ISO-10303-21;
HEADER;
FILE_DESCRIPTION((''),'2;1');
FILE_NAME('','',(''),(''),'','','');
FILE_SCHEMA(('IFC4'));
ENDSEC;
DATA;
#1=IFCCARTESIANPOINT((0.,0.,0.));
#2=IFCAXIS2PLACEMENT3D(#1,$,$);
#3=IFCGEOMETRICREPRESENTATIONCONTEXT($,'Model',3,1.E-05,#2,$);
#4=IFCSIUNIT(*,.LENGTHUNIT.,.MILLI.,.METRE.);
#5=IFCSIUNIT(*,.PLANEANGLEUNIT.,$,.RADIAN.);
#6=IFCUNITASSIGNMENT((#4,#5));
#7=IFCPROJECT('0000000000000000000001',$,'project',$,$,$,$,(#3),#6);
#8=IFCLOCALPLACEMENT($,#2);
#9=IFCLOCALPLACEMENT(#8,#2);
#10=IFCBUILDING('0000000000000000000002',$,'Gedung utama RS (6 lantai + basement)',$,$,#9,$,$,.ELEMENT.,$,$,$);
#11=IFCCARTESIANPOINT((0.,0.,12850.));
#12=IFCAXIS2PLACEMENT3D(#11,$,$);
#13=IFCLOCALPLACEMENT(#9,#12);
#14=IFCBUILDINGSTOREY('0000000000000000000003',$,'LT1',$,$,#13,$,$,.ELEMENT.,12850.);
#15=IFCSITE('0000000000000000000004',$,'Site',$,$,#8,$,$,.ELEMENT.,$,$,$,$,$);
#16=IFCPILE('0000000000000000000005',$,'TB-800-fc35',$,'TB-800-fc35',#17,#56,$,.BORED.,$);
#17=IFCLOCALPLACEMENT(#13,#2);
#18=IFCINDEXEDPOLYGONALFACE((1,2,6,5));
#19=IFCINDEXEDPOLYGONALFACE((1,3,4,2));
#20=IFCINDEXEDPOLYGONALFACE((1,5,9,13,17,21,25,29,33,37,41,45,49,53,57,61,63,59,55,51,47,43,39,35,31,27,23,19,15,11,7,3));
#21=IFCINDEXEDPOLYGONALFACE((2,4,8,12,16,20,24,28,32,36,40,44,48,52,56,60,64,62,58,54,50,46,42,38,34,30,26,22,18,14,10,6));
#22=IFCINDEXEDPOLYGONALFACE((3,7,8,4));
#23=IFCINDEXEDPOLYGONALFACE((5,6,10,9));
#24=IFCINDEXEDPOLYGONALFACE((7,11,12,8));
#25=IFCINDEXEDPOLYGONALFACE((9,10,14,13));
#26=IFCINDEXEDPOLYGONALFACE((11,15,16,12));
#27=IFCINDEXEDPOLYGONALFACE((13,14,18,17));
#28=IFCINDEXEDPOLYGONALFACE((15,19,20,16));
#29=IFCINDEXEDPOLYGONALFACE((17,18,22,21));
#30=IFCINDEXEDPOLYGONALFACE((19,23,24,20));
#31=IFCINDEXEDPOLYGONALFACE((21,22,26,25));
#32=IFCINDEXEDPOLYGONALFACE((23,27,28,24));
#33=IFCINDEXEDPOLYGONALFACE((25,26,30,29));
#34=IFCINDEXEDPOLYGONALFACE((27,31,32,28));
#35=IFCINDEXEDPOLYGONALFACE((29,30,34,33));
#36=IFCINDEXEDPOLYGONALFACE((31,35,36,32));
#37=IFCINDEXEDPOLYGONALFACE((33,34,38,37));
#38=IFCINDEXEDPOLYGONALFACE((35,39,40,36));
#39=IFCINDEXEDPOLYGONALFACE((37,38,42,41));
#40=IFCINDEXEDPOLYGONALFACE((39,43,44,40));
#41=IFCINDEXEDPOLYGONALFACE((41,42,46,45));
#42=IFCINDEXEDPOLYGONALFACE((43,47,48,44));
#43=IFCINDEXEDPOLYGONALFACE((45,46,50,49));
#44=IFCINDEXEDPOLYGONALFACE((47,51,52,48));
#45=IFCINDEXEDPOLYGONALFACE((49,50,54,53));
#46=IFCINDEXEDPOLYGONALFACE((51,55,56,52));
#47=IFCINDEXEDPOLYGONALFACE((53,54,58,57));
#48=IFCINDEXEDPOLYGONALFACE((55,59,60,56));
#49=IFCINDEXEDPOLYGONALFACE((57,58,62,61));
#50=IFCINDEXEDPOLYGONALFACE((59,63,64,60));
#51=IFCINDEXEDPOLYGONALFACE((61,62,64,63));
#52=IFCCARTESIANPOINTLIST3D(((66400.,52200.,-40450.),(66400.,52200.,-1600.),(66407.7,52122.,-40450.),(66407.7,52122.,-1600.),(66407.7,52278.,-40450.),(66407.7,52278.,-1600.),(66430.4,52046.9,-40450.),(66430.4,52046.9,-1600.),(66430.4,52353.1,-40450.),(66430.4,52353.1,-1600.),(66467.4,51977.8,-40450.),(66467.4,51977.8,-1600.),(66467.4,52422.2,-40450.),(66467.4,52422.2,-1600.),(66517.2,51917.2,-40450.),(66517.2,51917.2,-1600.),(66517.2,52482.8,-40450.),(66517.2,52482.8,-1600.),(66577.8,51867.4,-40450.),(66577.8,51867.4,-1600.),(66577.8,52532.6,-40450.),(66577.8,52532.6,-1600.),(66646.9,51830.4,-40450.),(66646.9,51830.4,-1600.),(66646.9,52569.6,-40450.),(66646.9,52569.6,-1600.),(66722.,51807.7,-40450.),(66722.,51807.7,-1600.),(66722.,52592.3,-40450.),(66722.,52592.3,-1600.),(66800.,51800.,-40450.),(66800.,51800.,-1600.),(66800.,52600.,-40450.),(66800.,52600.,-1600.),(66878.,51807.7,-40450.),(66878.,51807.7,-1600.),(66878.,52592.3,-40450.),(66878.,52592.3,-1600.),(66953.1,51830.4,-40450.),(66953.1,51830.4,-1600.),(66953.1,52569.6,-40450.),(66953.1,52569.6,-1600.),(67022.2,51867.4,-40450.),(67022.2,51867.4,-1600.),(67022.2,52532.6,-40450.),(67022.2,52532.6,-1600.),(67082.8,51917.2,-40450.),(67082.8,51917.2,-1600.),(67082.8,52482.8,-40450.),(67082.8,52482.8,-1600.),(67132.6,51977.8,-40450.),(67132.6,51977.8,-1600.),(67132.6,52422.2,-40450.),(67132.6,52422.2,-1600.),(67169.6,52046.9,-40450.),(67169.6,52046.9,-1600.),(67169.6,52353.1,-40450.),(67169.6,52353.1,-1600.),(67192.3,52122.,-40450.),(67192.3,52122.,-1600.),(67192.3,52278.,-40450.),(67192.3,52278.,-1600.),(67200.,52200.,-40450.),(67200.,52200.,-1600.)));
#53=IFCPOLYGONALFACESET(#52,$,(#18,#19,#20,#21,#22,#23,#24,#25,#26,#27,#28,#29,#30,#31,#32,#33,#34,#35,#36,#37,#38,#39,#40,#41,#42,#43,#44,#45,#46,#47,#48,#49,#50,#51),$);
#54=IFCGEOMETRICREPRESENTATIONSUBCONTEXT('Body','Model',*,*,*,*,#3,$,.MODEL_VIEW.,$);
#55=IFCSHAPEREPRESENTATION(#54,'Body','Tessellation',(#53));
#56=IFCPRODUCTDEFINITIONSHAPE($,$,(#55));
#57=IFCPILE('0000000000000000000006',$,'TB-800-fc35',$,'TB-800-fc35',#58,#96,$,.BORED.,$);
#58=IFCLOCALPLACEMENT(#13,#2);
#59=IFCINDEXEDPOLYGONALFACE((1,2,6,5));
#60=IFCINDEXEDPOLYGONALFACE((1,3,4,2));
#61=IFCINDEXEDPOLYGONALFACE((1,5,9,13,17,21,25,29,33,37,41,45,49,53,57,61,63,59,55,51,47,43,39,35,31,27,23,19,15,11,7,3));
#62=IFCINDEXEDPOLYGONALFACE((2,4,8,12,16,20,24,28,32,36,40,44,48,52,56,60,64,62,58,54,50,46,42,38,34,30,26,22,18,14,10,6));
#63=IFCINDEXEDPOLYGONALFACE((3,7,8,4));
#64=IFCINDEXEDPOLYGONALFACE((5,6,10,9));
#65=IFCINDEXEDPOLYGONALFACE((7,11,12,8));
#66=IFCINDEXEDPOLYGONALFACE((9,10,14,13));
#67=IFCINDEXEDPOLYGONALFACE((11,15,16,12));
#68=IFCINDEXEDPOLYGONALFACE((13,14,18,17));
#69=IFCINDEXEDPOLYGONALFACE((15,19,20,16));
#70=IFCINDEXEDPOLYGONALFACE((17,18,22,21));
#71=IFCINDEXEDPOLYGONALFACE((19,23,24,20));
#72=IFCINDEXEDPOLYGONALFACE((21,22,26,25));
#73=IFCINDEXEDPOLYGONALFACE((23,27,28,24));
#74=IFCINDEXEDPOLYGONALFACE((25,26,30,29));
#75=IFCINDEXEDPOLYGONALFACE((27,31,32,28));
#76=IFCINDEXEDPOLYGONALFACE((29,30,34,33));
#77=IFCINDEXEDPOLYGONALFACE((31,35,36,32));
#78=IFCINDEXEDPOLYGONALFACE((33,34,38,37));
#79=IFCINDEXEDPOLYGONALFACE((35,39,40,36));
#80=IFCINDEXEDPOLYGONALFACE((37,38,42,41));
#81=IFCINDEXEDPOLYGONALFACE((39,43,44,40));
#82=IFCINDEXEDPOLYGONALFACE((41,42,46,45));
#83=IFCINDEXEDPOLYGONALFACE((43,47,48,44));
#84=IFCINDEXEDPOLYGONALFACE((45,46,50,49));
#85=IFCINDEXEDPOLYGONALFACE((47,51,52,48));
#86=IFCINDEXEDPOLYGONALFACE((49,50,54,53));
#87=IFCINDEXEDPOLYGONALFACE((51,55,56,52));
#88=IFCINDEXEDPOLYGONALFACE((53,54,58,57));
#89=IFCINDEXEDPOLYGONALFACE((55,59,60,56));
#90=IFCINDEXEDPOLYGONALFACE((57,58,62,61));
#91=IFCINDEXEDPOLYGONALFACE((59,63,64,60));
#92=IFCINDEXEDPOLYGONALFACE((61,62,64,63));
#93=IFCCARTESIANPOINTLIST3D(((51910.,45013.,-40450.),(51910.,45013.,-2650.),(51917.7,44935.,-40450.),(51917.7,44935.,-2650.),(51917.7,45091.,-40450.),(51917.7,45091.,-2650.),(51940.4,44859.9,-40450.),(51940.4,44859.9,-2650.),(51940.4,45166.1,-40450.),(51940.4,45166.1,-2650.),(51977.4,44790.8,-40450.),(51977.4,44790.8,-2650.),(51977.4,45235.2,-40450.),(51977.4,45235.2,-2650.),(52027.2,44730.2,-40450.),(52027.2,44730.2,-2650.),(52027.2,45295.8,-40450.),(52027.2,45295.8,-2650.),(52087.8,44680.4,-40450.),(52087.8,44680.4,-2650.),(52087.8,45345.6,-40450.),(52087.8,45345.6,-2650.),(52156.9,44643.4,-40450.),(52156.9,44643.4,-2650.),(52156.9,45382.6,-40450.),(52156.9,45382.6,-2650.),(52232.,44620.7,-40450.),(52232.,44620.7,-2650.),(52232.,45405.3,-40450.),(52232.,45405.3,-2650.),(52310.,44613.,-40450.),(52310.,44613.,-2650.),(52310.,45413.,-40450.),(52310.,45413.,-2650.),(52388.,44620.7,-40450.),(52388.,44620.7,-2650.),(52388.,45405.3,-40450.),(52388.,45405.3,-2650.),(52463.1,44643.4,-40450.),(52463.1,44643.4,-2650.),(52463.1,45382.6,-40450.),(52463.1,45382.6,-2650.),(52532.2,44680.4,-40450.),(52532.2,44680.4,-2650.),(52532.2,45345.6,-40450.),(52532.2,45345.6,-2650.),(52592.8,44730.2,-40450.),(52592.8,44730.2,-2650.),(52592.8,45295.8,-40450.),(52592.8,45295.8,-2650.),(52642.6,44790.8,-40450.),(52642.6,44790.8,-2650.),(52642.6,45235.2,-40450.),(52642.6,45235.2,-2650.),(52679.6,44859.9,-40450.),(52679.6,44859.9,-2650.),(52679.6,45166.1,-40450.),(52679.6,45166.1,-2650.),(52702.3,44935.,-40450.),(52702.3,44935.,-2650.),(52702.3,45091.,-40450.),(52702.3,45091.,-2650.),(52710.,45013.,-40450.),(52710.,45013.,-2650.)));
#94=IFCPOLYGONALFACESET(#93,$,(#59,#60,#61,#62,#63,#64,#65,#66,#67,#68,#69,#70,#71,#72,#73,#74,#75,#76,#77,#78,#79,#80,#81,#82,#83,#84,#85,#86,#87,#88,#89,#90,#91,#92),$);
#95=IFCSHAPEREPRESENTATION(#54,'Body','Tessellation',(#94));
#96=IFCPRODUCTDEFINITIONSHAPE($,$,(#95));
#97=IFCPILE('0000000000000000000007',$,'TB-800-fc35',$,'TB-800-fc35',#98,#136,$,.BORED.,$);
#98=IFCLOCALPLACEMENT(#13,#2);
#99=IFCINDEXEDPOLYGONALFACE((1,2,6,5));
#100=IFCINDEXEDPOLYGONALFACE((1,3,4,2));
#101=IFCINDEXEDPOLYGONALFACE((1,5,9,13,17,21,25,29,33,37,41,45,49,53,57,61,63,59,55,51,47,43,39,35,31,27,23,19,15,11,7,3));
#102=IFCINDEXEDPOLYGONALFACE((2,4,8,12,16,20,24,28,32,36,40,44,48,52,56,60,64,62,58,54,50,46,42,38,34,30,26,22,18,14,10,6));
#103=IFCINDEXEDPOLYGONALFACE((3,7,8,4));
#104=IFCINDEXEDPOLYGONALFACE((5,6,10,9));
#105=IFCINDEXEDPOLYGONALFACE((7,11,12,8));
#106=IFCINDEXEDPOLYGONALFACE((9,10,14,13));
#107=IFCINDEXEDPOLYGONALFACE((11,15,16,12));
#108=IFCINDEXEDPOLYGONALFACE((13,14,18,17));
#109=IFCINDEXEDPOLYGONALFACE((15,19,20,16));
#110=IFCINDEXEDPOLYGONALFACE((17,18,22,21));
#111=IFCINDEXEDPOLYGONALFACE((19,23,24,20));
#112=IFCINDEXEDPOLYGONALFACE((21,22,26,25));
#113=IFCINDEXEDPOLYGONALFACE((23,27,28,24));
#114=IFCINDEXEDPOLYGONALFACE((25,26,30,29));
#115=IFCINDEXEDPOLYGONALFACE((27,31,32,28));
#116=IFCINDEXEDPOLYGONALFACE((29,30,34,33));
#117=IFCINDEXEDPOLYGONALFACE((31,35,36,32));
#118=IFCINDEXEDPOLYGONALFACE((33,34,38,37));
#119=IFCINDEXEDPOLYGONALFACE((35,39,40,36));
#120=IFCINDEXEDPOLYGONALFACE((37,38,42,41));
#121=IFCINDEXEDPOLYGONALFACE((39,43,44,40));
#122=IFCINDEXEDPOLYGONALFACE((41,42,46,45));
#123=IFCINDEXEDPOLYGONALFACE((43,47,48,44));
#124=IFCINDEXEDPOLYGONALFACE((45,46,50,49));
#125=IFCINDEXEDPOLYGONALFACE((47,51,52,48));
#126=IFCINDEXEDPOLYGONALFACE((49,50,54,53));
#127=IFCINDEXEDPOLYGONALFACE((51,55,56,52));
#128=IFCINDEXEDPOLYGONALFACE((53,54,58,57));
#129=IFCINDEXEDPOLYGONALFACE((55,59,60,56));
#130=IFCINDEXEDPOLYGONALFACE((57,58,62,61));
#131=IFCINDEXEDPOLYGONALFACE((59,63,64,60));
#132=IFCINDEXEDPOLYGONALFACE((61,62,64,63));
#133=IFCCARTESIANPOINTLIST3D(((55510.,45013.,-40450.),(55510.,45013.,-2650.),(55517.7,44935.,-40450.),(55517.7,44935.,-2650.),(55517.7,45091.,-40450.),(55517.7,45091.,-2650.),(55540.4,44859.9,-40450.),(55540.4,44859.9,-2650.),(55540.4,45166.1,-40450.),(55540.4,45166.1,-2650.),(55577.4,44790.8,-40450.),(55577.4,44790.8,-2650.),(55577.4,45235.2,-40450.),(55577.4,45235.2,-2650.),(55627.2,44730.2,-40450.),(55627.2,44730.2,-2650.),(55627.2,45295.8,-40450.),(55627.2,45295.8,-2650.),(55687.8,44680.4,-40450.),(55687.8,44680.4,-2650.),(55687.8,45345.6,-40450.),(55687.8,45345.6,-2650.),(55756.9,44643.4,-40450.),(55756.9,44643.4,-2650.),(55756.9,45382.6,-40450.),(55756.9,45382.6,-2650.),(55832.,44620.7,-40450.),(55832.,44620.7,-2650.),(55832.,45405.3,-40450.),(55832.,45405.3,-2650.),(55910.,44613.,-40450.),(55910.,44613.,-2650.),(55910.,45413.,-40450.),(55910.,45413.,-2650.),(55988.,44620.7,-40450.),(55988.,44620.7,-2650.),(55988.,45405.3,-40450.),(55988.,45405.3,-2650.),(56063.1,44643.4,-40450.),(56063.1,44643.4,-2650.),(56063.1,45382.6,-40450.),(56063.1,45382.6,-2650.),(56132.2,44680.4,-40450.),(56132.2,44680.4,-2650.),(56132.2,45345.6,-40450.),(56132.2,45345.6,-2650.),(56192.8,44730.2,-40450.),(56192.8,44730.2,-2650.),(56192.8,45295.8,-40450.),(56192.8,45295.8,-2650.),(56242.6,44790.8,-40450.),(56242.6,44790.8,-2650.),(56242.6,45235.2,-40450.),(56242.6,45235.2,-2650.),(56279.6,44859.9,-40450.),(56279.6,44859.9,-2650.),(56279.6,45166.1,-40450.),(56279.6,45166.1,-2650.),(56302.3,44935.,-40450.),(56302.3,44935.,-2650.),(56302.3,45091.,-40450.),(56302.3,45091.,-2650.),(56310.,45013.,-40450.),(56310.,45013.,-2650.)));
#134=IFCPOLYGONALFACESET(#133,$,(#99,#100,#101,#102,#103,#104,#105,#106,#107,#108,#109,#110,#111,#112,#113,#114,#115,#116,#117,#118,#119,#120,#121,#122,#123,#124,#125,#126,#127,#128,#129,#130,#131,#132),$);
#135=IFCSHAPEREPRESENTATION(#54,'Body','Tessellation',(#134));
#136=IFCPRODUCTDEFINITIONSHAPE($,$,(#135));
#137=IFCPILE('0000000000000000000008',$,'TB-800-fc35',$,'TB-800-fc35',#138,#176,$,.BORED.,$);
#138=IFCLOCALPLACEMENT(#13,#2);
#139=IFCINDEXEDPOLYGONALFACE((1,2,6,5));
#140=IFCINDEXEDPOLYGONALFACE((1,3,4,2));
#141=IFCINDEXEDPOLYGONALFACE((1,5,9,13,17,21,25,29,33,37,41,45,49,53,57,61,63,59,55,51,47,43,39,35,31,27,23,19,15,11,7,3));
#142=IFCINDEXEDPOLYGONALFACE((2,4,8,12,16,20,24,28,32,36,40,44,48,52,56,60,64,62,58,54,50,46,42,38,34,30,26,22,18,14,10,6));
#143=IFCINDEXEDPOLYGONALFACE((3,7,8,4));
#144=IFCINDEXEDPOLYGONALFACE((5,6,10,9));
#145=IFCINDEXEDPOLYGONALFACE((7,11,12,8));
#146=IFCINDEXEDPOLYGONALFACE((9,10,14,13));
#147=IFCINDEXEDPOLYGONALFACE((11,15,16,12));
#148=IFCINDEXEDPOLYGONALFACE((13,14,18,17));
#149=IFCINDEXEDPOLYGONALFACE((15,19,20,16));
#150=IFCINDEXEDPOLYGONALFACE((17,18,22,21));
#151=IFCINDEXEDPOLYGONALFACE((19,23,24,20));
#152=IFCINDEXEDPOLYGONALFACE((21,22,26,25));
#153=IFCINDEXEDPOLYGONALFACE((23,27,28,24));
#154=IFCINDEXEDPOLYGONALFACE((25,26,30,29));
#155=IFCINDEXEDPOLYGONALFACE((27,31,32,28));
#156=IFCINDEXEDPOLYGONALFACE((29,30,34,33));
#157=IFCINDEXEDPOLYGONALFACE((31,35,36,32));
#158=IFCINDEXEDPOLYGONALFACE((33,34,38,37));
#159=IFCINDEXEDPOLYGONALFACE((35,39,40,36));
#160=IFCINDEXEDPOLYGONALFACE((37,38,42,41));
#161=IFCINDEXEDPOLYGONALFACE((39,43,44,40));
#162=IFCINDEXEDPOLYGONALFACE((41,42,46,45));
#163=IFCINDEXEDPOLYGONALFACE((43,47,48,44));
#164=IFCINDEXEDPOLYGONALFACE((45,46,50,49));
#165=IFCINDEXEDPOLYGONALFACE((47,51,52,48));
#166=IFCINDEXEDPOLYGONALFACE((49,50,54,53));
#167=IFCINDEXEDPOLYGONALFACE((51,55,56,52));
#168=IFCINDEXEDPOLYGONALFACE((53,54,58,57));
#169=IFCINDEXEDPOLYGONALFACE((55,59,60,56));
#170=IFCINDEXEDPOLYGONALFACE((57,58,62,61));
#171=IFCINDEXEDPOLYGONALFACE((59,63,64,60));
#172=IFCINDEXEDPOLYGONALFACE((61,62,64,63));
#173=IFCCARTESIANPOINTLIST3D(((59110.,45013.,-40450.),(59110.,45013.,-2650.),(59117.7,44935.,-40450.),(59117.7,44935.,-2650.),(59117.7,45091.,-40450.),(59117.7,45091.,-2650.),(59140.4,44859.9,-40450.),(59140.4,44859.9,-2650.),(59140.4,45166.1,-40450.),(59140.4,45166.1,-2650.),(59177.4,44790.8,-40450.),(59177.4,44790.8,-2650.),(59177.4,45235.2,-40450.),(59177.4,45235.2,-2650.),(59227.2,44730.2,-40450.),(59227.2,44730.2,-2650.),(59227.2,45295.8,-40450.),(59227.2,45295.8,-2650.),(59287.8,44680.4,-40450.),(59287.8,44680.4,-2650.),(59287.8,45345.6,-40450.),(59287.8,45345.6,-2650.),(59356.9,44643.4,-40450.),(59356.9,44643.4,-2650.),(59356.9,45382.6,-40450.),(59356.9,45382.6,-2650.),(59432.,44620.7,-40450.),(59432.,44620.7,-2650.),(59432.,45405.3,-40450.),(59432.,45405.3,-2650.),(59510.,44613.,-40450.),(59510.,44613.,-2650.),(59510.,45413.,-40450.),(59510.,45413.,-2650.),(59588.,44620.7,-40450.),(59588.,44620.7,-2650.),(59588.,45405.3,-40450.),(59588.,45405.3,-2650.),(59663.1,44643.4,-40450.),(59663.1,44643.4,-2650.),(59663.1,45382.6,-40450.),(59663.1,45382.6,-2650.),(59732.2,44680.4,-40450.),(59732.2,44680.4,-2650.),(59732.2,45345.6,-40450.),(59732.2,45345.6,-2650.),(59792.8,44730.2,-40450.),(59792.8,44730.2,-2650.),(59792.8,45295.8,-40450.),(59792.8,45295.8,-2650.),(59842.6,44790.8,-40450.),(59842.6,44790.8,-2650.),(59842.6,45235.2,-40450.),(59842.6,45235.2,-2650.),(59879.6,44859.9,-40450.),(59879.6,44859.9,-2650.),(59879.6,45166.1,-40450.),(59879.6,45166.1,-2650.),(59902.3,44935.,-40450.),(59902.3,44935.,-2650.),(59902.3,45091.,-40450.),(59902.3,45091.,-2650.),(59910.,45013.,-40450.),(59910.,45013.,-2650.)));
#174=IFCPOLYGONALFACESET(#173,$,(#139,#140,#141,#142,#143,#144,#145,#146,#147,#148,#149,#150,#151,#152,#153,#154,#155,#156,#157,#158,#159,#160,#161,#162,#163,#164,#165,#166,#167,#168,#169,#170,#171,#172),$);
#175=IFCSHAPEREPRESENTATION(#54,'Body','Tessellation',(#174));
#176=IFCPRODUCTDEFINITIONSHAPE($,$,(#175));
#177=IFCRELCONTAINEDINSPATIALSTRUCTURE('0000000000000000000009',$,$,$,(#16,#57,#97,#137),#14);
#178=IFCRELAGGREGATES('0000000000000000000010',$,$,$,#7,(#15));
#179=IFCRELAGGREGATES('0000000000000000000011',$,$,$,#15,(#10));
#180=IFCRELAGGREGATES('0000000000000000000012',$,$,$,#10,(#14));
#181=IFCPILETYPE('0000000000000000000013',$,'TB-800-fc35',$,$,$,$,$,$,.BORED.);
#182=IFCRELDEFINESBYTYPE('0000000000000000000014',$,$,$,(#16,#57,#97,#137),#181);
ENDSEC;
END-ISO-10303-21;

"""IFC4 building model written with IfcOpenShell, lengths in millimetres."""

from ifc_helpers import new_model, si_unit, frame, origin, origin_2d, place, context, subcontext, project, spatial, circle, extrude, material_profile, profile_set, profile_usage, type_object, element, save


model = new_model("IFC4")

# Units and contexts
model_context = context("Model", 3, precision=1e-05, world=origin())
body_context = subcontext(model_context, "Body", "Model", "MODEL_VIEW")
ifc_project = project(units=[si_unit("LENGTHUNIT", "METRE", prefix="MILLI"), si_unit("PLANEANGLEUNIT", "RADIAN")], contexts=[model_context])

# Site, building, storey
site_placement = place(None, origin())
site = spatial("IfcSite", under=ifc_project, at=site_placement, Name="Site", CompositionType="ELEMENT")
building_placement = place(site_placement, origin())
building = spatial("IfcBuilding", under=site, at=building_placement, Name="Gedung utama RS (6 lantai + basement)", CompositionType="ELEMENT")
storey_placement = place(building_placement, frame((0.0, 0.0, 12850.0)))
storey = spatial("IfcBuildingStorey", under=building, at=storey_placement, Name="LT1", CompositionType="ELEMENT", Elevation=12850.0)

# Piles
ifc_material_profile = material_profile(None, circle(Radius=400.0, at=origin_2d()), Name="TB-800-fc35")
ifc_profile_set = profile_set([ifc_material_profile], Name="TB-800-fc35")
ifc_profile_usage = profile_usage(ifc_profile_set, cardinal=5)
pile_type = type_object("IfcPileType", Name="TB-800-fc35", PredefinedType="BORED", material=ifc_profile_set)
for number, where, z_axis, x_axis, name in (
    (1, (66800.0, 52200.0, -40450.0), (0.0, 0.0, 1.0), (1.0, 0.0, 0.0), "TB-800-fc35"),
):
    element("IfcPile", number, at=place(storey_placement, frame(where, z_axis=z_axis, x_axis=x_axis)), inside=storey, type_object=pile_type, material=ifc_profile_usage, Name=name, ObjectType="TB-800-fc35", PredefinedType="BORED", context=body_context, shape_type="SweptSolid", body=[
        extrude(circle(Radius=400.0, at=origin_2d()), origin(), (0.0, 0.0, 1.0), 38850.0),
    ])
for number, where, z_axis, x_axis, name in (
    (2, (52310.0, 45013.0, -40450.0), (0.0, 0.0, 1.0), (1.0, 0.0, 0.0), "TB-800-fc35"),
    (3, (55910.0, 45013.0, -40450.0), (0.0, 0.0, 1.0), (1.0, 0.0, 0.0), "TB-800-fc35"),
    (4, (59510.0, 45013.0, -40450.0), (0.0, 0.0, 1.0), (1.0, 0.0, 0.0), "TB-800-fc35"),
):
    element("IfcPile", number, at=place(storey_placement, frame(where, z_axis=z_axis, x_axis=x_axis)), inside=storey, type_object=pile_type, material=ifc_profile_usage, Name=name, ObjectType="TB-800-fc35", PredefinedType="BORED", context=body_context, shape_type="SweptSolid", body=[
        extrude(circle(Radius=400.0, at=origin_2d()), origin(), (0.0, 0.0, 1.0), 37800.0),
    ])

save(model, "model.ifc")
